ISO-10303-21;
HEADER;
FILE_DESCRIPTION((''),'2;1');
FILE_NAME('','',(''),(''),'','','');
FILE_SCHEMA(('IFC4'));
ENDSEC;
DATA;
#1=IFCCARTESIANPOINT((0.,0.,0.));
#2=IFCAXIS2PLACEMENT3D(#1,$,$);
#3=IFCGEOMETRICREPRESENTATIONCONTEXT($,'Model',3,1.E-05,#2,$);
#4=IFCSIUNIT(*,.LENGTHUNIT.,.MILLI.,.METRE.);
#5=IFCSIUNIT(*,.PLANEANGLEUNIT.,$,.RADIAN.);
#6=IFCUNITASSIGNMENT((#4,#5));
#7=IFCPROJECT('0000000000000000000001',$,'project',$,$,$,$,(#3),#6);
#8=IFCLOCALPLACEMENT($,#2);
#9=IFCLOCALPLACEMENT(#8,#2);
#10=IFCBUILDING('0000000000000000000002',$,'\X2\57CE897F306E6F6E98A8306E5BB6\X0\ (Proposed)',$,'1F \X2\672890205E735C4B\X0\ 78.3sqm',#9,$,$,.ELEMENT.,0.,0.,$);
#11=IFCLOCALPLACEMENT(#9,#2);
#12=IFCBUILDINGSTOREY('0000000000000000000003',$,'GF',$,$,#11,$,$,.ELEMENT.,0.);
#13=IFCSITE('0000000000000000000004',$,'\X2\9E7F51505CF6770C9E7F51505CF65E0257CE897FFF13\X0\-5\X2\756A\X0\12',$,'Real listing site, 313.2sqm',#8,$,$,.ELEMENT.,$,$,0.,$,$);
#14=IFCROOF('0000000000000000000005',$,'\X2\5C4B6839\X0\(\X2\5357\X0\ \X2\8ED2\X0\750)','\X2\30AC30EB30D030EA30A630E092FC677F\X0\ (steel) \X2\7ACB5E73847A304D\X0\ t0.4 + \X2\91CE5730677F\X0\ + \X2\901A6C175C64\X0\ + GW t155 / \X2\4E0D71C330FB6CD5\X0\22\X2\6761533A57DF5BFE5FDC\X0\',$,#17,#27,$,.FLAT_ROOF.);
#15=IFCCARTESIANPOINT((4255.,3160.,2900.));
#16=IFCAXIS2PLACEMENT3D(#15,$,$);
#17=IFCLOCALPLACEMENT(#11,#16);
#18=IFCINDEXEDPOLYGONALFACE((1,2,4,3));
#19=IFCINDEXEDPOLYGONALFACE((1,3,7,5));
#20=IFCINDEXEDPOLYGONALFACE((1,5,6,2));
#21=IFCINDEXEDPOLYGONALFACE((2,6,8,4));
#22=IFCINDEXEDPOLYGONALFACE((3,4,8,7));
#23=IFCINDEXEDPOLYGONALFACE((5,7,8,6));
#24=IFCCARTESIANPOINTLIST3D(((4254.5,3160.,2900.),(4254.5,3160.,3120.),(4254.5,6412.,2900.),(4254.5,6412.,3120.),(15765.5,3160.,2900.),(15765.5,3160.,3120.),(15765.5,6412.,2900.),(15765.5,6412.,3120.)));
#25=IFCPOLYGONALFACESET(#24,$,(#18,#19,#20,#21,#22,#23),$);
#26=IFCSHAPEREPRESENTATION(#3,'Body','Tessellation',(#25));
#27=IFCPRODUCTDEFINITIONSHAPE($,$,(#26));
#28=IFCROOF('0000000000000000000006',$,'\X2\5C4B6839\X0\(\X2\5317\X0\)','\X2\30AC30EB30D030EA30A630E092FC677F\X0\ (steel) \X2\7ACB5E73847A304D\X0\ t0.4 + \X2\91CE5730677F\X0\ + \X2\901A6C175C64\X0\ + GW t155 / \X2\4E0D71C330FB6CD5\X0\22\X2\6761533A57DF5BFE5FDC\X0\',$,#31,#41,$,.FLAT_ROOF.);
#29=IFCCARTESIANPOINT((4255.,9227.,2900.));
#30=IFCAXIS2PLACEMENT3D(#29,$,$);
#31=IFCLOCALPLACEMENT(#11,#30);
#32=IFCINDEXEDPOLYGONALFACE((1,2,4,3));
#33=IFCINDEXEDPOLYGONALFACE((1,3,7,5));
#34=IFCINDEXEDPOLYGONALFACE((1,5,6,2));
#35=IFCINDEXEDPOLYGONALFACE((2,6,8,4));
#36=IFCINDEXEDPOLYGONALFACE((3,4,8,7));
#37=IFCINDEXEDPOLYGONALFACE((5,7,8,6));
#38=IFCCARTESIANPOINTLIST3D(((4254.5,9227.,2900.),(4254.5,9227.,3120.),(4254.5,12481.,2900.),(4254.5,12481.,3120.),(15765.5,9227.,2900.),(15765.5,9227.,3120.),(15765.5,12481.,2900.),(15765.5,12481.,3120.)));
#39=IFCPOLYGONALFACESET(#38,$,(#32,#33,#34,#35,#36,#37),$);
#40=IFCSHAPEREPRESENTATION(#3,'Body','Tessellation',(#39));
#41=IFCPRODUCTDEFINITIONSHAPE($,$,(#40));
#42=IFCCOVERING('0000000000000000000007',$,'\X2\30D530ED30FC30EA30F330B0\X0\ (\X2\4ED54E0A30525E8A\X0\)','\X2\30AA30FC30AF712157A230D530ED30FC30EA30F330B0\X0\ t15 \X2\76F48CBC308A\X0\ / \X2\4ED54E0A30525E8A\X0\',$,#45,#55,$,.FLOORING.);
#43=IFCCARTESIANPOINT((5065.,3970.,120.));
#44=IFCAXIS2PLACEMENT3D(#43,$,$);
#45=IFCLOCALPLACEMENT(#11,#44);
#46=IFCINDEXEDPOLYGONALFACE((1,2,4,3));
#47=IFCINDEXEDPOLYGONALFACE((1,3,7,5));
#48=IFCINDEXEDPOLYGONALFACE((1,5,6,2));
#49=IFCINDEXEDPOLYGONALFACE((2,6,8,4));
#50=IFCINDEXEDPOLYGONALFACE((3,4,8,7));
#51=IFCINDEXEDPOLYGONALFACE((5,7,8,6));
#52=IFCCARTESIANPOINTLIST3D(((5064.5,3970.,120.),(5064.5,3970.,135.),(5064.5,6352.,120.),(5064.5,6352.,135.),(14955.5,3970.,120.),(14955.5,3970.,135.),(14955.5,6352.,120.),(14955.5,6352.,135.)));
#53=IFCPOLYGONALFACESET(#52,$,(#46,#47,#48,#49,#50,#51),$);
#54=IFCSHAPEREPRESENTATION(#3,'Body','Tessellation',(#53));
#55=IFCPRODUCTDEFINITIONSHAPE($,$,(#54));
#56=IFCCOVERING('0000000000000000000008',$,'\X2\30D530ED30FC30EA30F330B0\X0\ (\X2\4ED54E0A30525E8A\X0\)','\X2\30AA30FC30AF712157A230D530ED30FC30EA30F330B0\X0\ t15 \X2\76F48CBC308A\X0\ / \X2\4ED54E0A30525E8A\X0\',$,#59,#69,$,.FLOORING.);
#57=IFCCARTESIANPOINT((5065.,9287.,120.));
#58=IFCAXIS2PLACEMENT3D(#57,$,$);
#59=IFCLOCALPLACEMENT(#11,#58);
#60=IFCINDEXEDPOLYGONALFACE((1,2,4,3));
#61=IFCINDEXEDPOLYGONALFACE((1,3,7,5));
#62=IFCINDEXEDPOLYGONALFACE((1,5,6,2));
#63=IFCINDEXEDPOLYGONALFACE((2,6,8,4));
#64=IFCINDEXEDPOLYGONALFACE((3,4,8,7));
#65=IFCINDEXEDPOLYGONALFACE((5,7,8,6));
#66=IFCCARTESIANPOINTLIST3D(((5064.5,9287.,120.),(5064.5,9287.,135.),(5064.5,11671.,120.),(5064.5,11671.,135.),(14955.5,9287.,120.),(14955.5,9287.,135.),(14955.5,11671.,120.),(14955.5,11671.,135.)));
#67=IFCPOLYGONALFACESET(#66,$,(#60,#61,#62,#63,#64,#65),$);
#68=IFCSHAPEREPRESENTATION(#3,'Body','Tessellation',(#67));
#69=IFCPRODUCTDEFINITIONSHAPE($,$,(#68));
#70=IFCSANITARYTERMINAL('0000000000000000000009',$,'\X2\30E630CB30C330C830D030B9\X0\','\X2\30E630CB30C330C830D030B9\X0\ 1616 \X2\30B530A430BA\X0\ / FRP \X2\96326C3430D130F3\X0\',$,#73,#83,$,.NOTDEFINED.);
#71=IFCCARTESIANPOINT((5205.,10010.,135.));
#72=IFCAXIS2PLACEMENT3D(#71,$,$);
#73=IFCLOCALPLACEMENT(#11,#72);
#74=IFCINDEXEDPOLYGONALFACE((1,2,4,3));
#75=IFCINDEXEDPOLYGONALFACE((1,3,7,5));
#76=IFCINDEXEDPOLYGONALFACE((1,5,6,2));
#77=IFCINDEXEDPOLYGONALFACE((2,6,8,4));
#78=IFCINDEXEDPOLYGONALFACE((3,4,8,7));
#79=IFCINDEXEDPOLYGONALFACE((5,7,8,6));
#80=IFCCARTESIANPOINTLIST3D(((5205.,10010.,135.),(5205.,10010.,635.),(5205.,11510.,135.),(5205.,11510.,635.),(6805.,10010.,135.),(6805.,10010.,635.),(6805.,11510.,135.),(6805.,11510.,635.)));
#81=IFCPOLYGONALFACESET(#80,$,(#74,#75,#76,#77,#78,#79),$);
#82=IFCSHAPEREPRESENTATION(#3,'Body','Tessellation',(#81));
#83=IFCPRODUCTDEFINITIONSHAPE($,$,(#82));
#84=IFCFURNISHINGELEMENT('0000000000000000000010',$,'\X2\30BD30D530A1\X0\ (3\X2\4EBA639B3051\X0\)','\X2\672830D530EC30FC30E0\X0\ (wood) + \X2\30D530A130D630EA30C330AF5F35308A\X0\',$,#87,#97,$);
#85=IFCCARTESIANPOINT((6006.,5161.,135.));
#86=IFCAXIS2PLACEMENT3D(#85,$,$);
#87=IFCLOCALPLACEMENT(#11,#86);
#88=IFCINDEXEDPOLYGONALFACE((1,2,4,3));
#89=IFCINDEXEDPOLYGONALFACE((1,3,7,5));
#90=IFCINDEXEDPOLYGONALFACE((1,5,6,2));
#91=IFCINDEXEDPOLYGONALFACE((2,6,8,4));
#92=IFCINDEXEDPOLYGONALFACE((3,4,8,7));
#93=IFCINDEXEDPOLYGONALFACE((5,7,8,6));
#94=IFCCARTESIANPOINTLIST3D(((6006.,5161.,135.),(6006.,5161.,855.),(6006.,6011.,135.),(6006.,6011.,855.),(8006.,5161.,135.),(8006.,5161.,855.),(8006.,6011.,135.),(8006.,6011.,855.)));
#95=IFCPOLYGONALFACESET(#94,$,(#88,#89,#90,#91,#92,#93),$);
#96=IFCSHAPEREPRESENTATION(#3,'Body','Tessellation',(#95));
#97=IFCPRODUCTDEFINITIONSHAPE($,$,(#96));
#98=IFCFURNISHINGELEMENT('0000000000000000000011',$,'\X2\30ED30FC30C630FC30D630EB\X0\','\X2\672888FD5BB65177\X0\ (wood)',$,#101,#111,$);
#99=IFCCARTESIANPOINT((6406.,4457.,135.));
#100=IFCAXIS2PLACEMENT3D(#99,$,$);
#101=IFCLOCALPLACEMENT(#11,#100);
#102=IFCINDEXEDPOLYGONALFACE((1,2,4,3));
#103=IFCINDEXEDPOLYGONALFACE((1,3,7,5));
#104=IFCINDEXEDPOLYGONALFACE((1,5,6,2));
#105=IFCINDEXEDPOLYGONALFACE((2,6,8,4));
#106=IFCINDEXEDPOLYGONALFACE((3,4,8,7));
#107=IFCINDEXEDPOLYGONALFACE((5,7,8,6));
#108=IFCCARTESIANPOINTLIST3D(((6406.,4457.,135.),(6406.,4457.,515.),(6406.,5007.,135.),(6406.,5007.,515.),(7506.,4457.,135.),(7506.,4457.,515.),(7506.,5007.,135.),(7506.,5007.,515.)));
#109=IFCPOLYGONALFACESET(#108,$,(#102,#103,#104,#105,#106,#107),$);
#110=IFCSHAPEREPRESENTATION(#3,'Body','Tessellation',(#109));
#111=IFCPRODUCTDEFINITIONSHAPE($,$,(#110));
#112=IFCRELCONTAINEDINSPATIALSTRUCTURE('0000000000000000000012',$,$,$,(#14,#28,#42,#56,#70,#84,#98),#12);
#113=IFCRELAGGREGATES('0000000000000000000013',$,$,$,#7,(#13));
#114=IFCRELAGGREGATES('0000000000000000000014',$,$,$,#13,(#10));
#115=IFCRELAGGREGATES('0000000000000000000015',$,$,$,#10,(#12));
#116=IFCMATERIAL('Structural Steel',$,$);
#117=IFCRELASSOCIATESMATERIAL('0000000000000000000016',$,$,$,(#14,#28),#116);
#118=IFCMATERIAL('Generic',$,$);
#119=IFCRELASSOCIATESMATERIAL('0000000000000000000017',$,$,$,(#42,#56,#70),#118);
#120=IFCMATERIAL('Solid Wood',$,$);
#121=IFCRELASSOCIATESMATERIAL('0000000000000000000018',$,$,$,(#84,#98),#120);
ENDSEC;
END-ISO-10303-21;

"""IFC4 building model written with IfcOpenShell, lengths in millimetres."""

from ifc_helpers import new_model, si_unit, frame, frame_2d, origin, place, context, project, spatial, rectangle, extrude, material, element, save


model = new_model("IFC4")

# Units and contexts
model_context = context("Model", 3, precision=1e-05, world=origin())
ifc_project = project(units=[si_unit("LENGTHUNIT", "METRE", prefix="MILLI"), si_unit("PLANEANGLEUNIT", "RADIAN")], contexts=[model_context])

# Site, building, storey
site_placement = place(None, origin())
site = spatial("IfcSite", under=ifc_project, at=site_placement, Name="鹿児島県鹿児島市城西３-5番12", ObjectType="Real listing site, 313.2sqm", CompositionType="ELEMENT", RefElevation=0.0)
building_placement = place(site_placement, origin())
building = spatial("IfcBuilding", under=site, at=building_placement, Name="城西の潮風の家 (Proposed)", ObjectType="1F 木造平屋 78.3sqm", CompositionType="ELEMENT", ElevationOfRefHeight=0.0, ElevationOfTerrain=0.0)
storey_placement = place(building_placement, origin())
storey = spatial("IfcBuildingStorey", under=building, at=storey_placement, Name="GF", CompositionType="ELEMENT", Elevation=0.0)

# Shared definitions
ifc_material_1 = material(Name="Solid Wood")

# Roofs
ifc_material_2 = material(Name="Structural Steel")
roof_1_placement = place(storey_placement, frame((4255.0, 3160.0, 2900.0)))
element("IfcRoof", 1, at=roof_1_placement, inside=storey, material=ifc_material_2, Name="屋根(南 軒750)", Description="ガルバリウム鋼板 (steel) 立平葺き t0.4 + 野地板 + 通気層 + GW t155 / 不燃・法22条区域対応", PredefinedType="FLAT_ROOF", context=model_context, shape_type="SweptSolid", body=[
    extrude(rectangle(XDim=11511.0, YDim=3252.0, at=frame_2d((5755.0, 1626.0))), frame((4255.0, 3160.0, 2900.0)), (0.0, 0.0, 1.0), 220.0),
])
roof_2_placement = place(storey_placement, frame((4255.0, 9227.0, 2900.0)))
element("IfcRoof", 2, at=roof_2_placement, inside=storey, material=ifc_material_2, Name="屋根(北)", Description="ガルバリウム鋼板 (steel) 立平葺き t0.4 + 野地板 + 通気層 + GW t155 / 不燃・法22条区域対応", PredefinedType="FLAT_ROOF", context=model_context, shape_type="SweptSolid", body=[
    extrude(rectangle(XDim=11511.0, YDim=3254.0, at=frame_2d((5755.0, 1627.0))), frame((4255.0, 9227.0, 2900.0)), (0.0, 0.0, 1.0), 220.0),
])

# Coverings
ifc_material_3 = material(Name="Generic")
covering_1_placement = place(storey_placement, frame((5065.0, 3970.0, 120.0)))
element("IfcCovering", 3, at=covering_1_placement, inside=storey, material=ifc_material_3, Name="フローリング (仕上げ床)", Description="オーク無垢フローリング t15 直貼り / 仕上げ床", PredefinedType="FLOORING", context=model_context, shape_type="SweptSolid", body=[
    extrude(rectangle(XDim=9891.0, YDim=2382.0, at=frame_2d((4945.0, 1191.0))), frame((5065.0, 3970.0, 120.0)), (0.0, 0.0, 1.0), 15.0),
])
covering_2_placement = place(storey_placement, frame((5065.0, 9287.0, 120.0)))
element("IfcCovering", 4, at=covering_2_placement, inside=storey, material=ifc_material_3, Name="フローリング (仕上げ床)", Description="オーク無垢フローリング t15 直貼り / 仕上げ床", PredefinedType="FLOORING", context=model_context, shape_type="SweptSolid", body=[
    extrude(rectangle(XDim=9891.0, YDim=2384.0, at=frame_2d((4945.0, 1192.0))), frame((5065.0, 9287.0, 120.0)), (0.0, 0.0, 1.0), 15.0),
])

# Sanitary terminal
sanitary_terminal_placement = place(storey_placement, frame((5205.0, 10010.0, 135.0)))
element("IfcSanitaryTerminal", 5, at=sanitary_terminal_placement, inside=storey, material=ifc_material_3, Name="ユニットバス", Description="ユニットバス 1616 サイズ / FRP 防水パン", PredefinedType="NOTDEFINED", context=model_context, shape_type="SweptSolid", body=[
    extrude(rectangle(XDim=1600.0, YDim=1500.0, at=frame_2d((800.0, 750.0))), frame((5205.0, 10010.0, 135.0)), (0.0, 0.0, 1.0), 500.0),
])

# Furnishing elements
furnishing_1_placement = place(storey_placement, frame((6006.0, 5161.0, 135.0)))
element("IfcFurnishingElement", 6, at=furnishing_1_placement, inside=storey, material=ifc_material_1, Name="ソファ (3人掛け)", Description="木フレーム (wood) + ファブリック張り", context=model_context, shape_type="SweptSolid", body=[
    extrude(rectangle(XDim=2000.0, YDim=850.0, at=frame_2d((1000.0, 425.0))), frame((6006.0, 5161.0, 135.0)), (0.0, 0.0, 1.0), 720.0),
])
furnishing_2_placement = place(storey_placement, frame((6406.0, 4457.0, 135.0)))
element("IfcFurnishingElement", 7, at=furnishing_2_placement, inside=storey, material=ifc_material_1, Name="ローテーブル", Description="木製家具 (wood)", context=model_context, shape_type="SweptSolid", body=[
    extrude(rectangle(XDim=1100.0, YDim=550.0, at=frame_2d((550.0, 275.0))), frame((6406.0, 4457.0, 135.0)), (0.0, 0.0, 1.0), 380.0),
])

save(model, "model.ifc")
